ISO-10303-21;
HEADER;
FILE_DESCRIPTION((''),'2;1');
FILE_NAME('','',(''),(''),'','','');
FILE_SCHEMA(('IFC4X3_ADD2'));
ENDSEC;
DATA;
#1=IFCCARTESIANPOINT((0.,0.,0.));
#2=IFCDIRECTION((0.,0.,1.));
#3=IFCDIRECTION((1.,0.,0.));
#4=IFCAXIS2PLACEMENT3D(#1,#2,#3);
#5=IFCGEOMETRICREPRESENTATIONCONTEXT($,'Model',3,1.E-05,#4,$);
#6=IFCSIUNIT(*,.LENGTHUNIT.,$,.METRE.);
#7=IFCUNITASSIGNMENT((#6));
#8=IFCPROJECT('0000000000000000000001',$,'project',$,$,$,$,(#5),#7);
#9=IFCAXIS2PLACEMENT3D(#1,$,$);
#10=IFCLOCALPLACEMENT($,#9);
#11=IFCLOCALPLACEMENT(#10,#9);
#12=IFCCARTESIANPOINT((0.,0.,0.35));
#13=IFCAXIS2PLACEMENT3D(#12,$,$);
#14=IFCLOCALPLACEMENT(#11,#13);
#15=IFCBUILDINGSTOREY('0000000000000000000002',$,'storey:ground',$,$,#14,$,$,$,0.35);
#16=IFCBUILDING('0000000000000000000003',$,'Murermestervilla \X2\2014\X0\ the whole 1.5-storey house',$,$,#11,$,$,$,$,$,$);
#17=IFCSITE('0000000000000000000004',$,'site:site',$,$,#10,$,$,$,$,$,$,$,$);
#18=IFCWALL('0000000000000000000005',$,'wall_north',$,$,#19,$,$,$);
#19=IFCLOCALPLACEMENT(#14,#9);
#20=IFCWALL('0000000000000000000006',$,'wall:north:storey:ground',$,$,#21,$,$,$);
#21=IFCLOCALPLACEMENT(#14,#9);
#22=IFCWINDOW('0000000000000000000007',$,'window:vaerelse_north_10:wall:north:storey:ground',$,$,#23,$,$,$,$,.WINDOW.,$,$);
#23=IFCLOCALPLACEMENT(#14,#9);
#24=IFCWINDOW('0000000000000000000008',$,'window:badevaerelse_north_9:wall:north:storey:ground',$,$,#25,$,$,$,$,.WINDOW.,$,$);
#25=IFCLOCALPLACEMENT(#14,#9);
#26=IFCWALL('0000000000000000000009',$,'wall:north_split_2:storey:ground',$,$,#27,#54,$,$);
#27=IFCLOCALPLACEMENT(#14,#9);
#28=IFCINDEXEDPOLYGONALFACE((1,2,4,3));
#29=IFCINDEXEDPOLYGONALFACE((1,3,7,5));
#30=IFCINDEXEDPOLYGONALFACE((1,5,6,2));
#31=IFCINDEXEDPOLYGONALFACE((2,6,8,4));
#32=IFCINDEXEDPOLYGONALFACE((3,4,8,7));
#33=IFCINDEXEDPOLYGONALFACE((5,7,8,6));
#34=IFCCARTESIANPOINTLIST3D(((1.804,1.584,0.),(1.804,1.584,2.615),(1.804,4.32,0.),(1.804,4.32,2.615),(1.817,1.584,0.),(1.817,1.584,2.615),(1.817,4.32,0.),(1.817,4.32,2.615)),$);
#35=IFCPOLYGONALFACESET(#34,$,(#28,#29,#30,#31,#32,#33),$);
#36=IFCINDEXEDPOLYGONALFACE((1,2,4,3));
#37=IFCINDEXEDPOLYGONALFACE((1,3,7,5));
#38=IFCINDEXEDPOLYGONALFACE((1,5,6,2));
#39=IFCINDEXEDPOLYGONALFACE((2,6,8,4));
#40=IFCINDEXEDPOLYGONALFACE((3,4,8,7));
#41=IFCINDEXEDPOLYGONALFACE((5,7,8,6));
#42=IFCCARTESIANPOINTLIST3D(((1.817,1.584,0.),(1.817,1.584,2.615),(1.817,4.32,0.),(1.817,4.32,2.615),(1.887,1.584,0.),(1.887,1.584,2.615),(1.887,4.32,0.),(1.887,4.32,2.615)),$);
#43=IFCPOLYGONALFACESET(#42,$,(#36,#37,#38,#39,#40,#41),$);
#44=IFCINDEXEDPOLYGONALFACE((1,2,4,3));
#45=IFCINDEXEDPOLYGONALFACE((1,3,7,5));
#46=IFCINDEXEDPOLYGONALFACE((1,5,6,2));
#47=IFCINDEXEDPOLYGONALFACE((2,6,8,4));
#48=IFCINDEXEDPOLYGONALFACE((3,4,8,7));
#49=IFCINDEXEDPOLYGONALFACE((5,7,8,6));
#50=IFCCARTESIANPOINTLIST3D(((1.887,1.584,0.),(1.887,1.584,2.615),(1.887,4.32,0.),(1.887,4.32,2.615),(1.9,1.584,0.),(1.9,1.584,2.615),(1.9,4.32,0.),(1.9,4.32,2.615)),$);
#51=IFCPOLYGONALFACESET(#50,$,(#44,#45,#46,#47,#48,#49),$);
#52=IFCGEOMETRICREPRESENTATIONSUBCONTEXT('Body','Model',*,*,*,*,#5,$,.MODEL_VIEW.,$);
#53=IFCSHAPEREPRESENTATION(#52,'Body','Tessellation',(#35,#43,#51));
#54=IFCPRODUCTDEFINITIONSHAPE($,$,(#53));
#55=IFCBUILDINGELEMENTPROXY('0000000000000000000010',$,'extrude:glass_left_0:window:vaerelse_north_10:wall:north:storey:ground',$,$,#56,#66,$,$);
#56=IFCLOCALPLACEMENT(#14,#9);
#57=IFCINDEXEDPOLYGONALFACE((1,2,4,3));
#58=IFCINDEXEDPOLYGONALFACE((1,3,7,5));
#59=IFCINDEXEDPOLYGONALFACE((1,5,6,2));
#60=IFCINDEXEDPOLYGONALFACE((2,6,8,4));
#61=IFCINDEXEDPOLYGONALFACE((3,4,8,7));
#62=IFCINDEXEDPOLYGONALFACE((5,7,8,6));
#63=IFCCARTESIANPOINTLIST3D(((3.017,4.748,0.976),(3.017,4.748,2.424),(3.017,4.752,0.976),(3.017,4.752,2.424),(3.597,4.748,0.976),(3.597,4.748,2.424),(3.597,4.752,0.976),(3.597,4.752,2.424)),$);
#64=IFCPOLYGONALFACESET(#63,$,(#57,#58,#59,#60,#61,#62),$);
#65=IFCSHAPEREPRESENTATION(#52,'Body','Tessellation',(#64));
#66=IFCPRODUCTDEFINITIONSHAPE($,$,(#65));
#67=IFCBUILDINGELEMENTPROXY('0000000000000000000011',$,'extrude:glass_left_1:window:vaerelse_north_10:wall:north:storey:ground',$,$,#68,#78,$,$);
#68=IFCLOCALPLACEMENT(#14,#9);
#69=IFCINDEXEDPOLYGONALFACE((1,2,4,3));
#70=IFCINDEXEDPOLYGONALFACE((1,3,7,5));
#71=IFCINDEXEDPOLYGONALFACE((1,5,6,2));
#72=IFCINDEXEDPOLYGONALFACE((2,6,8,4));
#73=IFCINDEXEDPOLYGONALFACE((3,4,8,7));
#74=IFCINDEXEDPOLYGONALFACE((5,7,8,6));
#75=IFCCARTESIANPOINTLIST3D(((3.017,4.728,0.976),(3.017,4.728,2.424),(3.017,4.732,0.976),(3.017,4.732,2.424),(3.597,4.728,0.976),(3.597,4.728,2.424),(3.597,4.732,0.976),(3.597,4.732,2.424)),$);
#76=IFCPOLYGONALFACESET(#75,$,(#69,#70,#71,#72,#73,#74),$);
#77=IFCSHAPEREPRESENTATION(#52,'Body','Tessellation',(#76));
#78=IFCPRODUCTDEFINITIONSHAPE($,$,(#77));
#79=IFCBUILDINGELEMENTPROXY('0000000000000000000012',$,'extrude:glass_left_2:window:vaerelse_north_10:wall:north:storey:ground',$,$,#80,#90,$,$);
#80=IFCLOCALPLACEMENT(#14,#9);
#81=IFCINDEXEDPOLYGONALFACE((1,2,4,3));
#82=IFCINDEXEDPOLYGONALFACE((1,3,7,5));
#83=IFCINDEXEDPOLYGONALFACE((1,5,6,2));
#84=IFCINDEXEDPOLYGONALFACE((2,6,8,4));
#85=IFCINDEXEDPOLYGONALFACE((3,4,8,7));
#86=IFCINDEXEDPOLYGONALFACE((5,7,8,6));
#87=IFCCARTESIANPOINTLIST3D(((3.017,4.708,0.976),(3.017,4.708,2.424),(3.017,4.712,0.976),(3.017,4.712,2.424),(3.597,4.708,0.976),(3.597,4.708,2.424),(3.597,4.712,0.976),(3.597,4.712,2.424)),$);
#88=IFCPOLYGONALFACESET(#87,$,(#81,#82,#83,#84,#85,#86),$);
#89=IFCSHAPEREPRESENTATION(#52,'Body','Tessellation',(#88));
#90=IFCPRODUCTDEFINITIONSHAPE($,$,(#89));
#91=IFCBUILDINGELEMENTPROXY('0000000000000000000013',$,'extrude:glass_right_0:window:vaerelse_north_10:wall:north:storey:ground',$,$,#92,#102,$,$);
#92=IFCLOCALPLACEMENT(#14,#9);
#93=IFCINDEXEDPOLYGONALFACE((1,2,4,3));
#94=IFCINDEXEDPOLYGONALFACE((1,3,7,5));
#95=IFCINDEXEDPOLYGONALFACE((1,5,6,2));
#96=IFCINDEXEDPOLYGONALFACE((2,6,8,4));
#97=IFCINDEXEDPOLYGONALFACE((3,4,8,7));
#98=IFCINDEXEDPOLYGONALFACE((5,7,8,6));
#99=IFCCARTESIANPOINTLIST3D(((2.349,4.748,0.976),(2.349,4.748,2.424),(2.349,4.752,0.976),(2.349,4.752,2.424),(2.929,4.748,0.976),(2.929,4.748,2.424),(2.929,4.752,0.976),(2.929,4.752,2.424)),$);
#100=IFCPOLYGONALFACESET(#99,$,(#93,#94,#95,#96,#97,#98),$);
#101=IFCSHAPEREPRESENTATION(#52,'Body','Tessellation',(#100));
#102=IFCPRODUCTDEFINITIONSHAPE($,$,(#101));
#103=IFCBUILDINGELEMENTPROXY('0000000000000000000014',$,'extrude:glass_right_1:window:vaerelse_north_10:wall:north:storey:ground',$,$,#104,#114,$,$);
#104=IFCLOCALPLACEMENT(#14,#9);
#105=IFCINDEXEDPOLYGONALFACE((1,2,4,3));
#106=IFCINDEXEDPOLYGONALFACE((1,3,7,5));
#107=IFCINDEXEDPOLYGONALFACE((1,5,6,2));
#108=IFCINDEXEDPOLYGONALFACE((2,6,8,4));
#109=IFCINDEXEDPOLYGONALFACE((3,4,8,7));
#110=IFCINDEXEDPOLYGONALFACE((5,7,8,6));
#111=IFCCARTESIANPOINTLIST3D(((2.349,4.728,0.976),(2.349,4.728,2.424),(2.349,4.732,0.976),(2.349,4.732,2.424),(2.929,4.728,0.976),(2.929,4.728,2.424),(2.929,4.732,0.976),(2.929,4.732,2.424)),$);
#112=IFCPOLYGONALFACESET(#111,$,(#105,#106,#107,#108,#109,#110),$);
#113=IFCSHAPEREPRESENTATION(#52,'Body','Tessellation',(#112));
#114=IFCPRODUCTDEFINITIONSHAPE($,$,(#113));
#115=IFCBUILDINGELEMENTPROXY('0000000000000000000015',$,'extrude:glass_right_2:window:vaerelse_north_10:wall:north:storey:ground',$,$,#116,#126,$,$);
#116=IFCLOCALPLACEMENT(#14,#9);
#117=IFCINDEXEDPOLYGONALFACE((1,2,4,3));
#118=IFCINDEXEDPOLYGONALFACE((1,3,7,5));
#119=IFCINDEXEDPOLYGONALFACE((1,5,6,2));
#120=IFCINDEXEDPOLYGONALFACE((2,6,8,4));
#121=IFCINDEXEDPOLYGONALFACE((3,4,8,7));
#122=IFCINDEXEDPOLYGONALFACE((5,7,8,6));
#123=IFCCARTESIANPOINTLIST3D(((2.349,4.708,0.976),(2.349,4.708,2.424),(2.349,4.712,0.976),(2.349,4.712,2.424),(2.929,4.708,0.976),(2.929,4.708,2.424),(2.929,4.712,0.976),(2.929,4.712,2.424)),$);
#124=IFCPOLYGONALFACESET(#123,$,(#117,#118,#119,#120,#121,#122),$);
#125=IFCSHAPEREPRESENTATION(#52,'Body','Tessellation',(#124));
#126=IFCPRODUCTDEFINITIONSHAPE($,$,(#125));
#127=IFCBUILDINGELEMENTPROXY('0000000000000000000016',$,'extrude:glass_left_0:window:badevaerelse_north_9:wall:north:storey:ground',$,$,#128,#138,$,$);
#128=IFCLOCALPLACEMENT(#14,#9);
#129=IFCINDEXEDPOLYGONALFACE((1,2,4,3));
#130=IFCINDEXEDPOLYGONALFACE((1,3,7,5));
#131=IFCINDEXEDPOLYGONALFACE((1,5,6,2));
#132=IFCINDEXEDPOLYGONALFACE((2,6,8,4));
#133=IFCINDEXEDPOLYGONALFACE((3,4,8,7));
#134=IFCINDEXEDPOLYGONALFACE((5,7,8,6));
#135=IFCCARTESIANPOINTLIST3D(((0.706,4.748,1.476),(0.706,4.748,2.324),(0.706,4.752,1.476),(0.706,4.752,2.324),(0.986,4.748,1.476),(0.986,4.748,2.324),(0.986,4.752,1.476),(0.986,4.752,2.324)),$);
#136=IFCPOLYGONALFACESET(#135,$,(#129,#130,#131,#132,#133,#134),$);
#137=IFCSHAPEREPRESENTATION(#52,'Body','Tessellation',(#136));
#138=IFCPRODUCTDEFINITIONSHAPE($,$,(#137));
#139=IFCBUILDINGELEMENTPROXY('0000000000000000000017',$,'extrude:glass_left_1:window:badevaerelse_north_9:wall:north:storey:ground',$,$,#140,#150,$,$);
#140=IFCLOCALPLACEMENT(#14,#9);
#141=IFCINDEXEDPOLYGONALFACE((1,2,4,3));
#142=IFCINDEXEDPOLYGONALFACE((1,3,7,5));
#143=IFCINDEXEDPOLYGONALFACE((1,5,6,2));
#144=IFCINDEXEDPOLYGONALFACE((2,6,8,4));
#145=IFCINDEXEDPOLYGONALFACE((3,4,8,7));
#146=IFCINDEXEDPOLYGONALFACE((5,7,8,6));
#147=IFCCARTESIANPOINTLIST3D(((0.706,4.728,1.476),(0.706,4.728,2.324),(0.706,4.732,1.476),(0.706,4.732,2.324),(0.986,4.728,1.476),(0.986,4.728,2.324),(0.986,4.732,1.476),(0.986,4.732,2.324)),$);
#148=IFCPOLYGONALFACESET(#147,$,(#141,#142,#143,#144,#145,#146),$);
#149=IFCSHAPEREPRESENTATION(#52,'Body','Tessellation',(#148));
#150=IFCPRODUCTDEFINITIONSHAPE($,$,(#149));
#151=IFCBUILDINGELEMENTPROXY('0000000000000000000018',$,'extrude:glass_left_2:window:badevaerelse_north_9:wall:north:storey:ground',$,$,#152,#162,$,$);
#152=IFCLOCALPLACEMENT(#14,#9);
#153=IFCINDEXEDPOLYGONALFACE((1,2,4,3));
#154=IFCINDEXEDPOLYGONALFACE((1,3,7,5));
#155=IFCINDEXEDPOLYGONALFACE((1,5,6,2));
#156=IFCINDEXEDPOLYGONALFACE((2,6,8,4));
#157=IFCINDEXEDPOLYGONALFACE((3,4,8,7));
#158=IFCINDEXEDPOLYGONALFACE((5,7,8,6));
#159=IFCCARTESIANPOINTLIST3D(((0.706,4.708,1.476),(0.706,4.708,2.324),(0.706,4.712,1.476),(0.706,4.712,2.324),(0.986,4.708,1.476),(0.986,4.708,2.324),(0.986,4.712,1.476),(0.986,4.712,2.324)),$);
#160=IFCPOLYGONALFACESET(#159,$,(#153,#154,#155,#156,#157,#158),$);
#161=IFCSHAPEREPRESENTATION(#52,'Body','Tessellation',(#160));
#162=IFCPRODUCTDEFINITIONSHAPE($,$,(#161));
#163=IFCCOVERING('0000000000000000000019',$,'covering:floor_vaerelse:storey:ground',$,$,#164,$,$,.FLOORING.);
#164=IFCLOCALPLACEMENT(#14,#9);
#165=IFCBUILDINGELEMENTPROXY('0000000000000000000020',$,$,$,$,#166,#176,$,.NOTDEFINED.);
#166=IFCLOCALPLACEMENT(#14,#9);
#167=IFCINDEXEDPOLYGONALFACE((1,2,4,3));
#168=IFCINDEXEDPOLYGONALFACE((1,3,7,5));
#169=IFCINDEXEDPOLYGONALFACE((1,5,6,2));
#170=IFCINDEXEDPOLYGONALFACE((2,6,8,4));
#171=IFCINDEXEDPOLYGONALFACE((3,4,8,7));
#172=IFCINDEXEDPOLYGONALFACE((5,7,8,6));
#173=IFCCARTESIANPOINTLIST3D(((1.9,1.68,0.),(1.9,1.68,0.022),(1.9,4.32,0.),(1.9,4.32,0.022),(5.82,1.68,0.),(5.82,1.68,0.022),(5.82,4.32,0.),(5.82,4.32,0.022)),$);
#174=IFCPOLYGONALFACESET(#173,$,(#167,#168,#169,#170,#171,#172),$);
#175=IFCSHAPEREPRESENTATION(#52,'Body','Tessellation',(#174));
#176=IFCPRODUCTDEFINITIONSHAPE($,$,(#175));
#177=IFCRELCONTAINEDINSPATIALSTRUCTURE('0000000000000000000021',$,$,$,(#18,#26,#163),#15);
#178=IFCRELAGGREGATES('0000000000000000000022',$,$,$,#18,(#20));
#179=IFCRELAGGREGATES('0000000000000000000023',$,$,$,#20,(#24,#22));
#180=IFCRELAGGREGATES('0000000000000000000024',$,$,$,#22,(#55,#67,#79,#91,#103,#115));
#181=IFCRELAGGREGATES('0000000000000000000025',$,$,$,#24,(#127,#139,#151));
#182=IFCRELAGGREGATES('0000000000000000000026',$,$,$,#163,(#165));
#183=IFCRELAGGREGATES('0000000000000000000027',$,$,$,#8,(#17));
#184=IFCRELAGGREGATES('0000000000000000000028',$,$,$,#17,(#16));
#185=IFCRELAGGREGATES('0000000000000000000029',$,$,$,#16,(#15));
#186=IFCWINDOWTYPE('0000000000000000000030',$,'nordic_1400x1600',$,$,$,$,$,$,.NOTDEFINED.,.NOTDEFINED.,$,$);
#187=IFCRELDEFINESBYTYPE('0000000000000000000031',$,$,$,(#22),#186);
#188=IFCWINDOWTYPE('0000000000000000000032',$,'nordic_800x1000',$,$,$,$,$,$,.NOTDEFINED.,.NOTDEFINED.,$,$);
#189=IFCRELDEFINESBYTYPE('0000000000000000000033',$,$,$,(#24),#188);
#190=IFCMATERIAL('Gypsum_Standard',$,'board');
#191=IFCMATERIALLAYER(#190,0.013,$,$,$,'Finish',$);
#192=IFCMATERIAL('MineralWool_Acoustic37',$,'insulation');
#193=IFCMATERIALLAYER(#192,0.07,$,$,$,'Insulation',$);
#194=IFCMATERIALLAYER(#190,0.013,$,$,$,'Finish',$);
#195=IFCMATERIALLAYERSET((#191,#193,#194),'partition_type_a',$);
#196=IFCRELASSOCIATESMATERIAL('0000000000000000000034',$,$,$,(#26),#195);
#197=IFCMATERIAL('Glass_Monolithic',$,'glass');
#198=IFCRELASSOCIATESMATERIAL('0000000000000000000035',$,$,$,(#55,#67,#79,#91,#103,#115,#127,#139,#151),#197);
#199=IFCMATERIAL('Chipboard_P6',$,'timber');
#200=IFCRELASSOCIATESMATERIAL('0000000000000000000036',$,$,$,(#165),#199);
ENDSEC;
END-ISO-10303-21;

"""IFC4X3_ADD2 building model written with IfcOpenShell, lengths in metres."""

from ifc_helpers import new_model, si_unit, frame, origin, origin_with_axes, place, context, subcontext, project, spatial, polyline, rectangle, outline, extrude, source, transform, mapped, material, layer, layer_set, layer_usage, type_object, element, aggregate, save


model = new_model("IFC4X3_ADD2")

# Units and contexts
model_context = context("Model", 3, precision=1e-05, world=origin_with_axes())
body_context = subcontext(model_context, "Body", "Model", "MODEL_VIEW")
ifc_project = project(units=[si_unit("LENGTHUNIT", "METRE")], contexts=[model_context])

# Site, building, storey
site_placement = place(None, origin())
site = spatial("IfcSite", under=ifc_project, at=site_placement, Name="site:site")
building_placement = place(site_placement, origin())
building = spatial("IfcBuilding", under=site, at=building_placement, Name="Murermestervilla — the whole 1.5-storey house")
storey_placement = place(building_placement, frame((0.0, 0.0, 0.35)))
storey = spatial("IfcBuildingStorey", under=building, at=storey_placement, Name="storey:ground", Elevation=0.35)

# Walls, windows
wall_1_placement = place(storey_placement, origin())
wall_1 = element("IfcWall", 1, at=wall_1_placement, inside=storey, Name="wall_north")
wall_2_placement = place(wall_1_placement, frame((0.0, 0.0, -0.35)))
wall_2 = element("IfcWall", 2, at=wall_2_placement, Name="wall:north:storey:ground")
aggregate(wall_1, [wall_2])
window_type_1 = type_object("IfcWindowType", Name="nordic_1400x1600", PartitioningType="NOTDEFINED", PredefinedType="NOTDEFINED")
window_1_placement = place(None, frame((2.973, 4.828, 1.25), z_axis=(0.0, 0.0, 1.0), x_axis=(-1.0, 0.0, 0.0)))
window_1 = element("IfcWindow", 3, at=window_1_placement, type_object=window_type_1, Name="window:vaerelse_north_10:wall:north:storey:ground", PredefinedType="WINDOW")
window_type_2 = type_object("IfcWindowType", Name="nordic_800x1000", PartitioningType="NOTDEFINED", PredefinedType="NOTDEFINED")
window_2_placement = place(None, frame((0.662, 4.828, 1.75), z_axis=(0.0, 0.0, 1.0), x_axis=(-1.0, 0.0, 0.0)))
window_2 = element("IfcWindow", 4, at=window_2_placement, type_object=window_type_2, Name="window:badevaerelse_north_9:wall:north:storey:ground", PredefinedType="WINDOW")
aggregate(wall_2, [window_2, window_1])

# Shared definitions
ifc_material_1 = material(Name="Gypsum_Standard", Category="board")
ifc_layer_1 = layer(ifc_material_1, 0.013, Category="Finish")
ifc_material_2 = material(Name="MineralWool_Acoustic37", Category="insulation")
ifc_layer_2 = layer(ifc_material_2, 0.07, Category="Insulation")
ifc_layer_3 = layer(ifc_material_1, 0.013, Category="Finish")
ifc_layer_set = layer_set([ifc_layer_1, ifc_layer_2, ifc_layer_3], Name="partition_type_a")

# Wall
ifc_layer_usage_1 = layer_usage(ifc_layer_set, "AXIS1", "NEGATIVE", 0.048)
wall_3_placement = place(storey_placement, frame((1.852, 2.952, 1.3075)))
element("IfcWall", 5, at=wall_3_placement, inside=storey, material=ifc_layer_usage_1, Name="wall:north_split_2:storey:ground", context=body_context, shape_type="SweptSolid", body=[
    extrude(rectangle(XDim=0.013, YDim=2.736), frame((-0.0415, 0.0, -1.3075)), (0.0, 0.0, 1.0), 2.615),
    extrude(rectangle(XDim=0.07, YDim=2.736), frame((0.0, 0.0, -1.3075)), (0.0, 0.0, 1.0), 2.615),
    extrude(rectangle(XDim=0.013, YDim=2.736), frame((0.0415, 0.0, -1.3075)), (0.0, 0.0, 1.0), 2.615),
])

# Building element proxies
ifc_material_3 = material(Name="Glass_Monolithic", Category="glass")
shared_shape_1 = source(origin(), body_context, "Body", "SweptSolid", [
    extrude(outline(polyline([(-0.29, -0.724), (0.29, -0.724), (0.29, 0.724), (-0.29, 0.724), (-0.29, -0.724)])), frame((0.0, 0.0, -0.002)), (0.0, 0.0, 1.0), 0.004),
])
proxy_1_placement = place(None, frame((3.307, 4.75, 2.05), z_axis=(0.0, 1.0, 0.0), x_axis=(-1.0, 0.0, 0.0)))
proxy_1 = element("IfcBuildingElementProxy", 6, at=proxy_1_placement, material=ifc_material_3, Name="extrude:glass_left_0:window:vaerelse_north_10:wall:north:storey:ground", context=body_context, shape_type="MappedRepresentation", body=[
    mapped(shared_shape_1, transform((0.0, 0.0, 0.0))),
])
shared_shape_2 = source(origin(), body_context, "Body", "SweptSolid", [
    extrude(outline(polyline([(-0.29, -0.724), (0.29, -0.724), (0.29, 0.724), (-0.29, 0.724), (-0.29, -0.724)])), frame((0.0, 0.0, -0.002)), (0.0, 0.0, 1.0), 0.004),
])
proxy_2_placement = place(None, frame((3.307, 4.73, 2.05), z_axis=(0.0, 1.0, 0.0), x_axis=(-1.0, 0.0, 0.0)))
proxy_2 = element("IfcBuildingElementProxy", 7, at=proxy_2_placement, material=ifc_material_3, Name="extrude:glass_left_1:window:vaerelse_north_10:wall:north:storey:ground", context=body_context, shape_type="MappedRepresentation", body=[
    mapped(shared_shape_2, transform((0.0, 0.0, 0.0))),
])
shared_shape_3 = source(origin(), body_context, "Body", "SweptSolid", [
    extrude(outline(polyline([(-0.29, -0.724), (0.29, -0.724), (0.29, 0.724), (-0.29, 0.724), (-0.29, -0.724)])), frame((0.0, 0.0, -0.002)), (0.0, 0.0, 1.0), 0.004),
])
proxy_3_placement = place(None, frame((3.307, 4.71, 2.05), z_axis=(0.0, 1.0, 0.0), x_axis=(-1.0, 0.0, 0.0)))
proxy_3 = element("IfcBuildingElementProxy", 8, at=proxy_3_placement, material=ifc_material_3, Name="extrude:glass_left_2:window:vaerelse_north_10:wall:north:storey:ground", context=body_context, shape_type="MappedRepresentation", body=[
    mapped(shared_shape_3, transform((0.0, 0.0, 0.0))),
])
shared_shape_4 = source(origin(), body_context, "Body", "SweptSolid", [
    extrude(outline(polyline([(-0.29, -0.724), (0.29, -0.724), (0.29, 0.724), (-0.29, 0.724), (-0.29, -0.724)])), frame((0.0, 0.0, -0.002)), (0.0, 0.0, 1.0), 0.004),
])
proxy_4_placement = place(None, frame((2.639, 4.75, 2.05), z_axis=(0.0, 1.0, 0.0), x_axis=(-1.0, 0.0, 0.0)))
proxy_4 = element("IfcBuildingElementProxy", 9, at=proxy_4_placement, material=ifc_material_3, Name="extrude:glass_right_0:window:vaerelse_north_10:wall:north:storey:ground", context=body_context, shape_type="MappedRepresentation", body=[
    mapped(shared_shape_4, transform((0.0, 0.0, 0.0))),
])
shared_shape_5 = source(origin(), body_context, "Body", "SweptSolid", [
    extrude(outline(polyline([(-0.29, -0.724), (0.29, -0.724), (0.29, 0.724), (-0.29, 0.724), (-0.29, -0.724)])), frame((0.0, 0.0, -0.002)), (0.0, 0.0, 1.0), 0.004),
])
proxy_5_placement = place(None, frame((2.639, 4.73, 2.05), z_axis=(0.0, 1.0, 0.0), x_axis=(-1.0, 0.0, 0.0)))
proxy_5 = element("IfcBuildingElementProxy", 10, at=proxy_5_placement, material=ifc_material_3, Name="extrude:glass_right_1:window:vaerelse_north_10:wall:north:storey:ground", context=body_context, shape_type="MappedRepresentation", body=[
    mapped(shared_shape_5, transform((0.0, 0.0, 0.0))),
])
shared_shape_6 = source(origin(), body_context, "Body", "SweptSolid", [
    extrude(outline(polyline([(-0.29, -0.724), (0.29, -0.724), (0.29, 0.724), (-0.29, 0.724), (-0.29, -0.724)])), frame((0.0, 0.0, -0.002)), (0.0, 0.0, 1.0), 0.004),
])
proxy_6_placement = place(None, frame((2.639, 4.71, 2.05), z_axis=(0.0, 1.0, 0.0), x_axis=(-1.0, 0.0, 0.0)))
proxy_6 = element("IfcBuildingElementProxy", 11, at=proxy_6_placement, material=ifc_material_3, Name="extrude:glass_right_2:window:vaerelse_north_10:wall:north:storey:ground", context=body_context, shape_type="MappedRepresentation", body=[
    mapped(shared_shape_6, transform((0.0, 0.0, 0.0))),
])
aggregate(window_1, [proxy_1, proxy_2, proxy_3, proxy_4, proxy_5, proxy_6])
shared_shape_7 = source(origin(), body_context, "Body", "SweptSolid", [
    extrude(outline(polyline([(-0.14, -0.424), (0.14, -0.424), (0.14, 0.424), (-0.14, 0.424), (-0.14, -0.424)])), frame((0.0, 0.0, -0.002)), (0.0, 0.0, 1.0), 0.004),
])
proxy_7_placement = place(None, frame((0.846, 4.75, 2.25), z_axis=(0.0, 1.0, 0.0), x_axis=(-1.0, 0.0, 0.0)))
proxy_7 = element("IfcBuildingElementProxy", 12, at=proxy_7_placement, material=ifc_material_3, Name="extrude:glass_left_0:window:badevaerelse_north_9:wall:north:storey:ground", context=body_context, shape_type="MappedRepresentation", body=[
    mapped(shared_shape_7, transform((0.0, 0.0, 0.0))),
])
shared_shape_8 = source(origin(), body_context, "Body", "SweptSolid", [
    extrude(outline(polyline([(-0.14, -0.424), (0.14, -0.424), (0.14, 0.424), (-0.14, 0.424), (-0.14, -0.424)])), frame((0.0, 0.0, -0.002)), (0.0, 0.0, 1.0), 0.004),
])
proxy_8_placement = place(None, frame((0.846, 4.73, 2.25), z_axis=(0.0, 1.0, 0.0), x_axis=(-1.0, 0.0, 0.0)))
proxy_8 = element("IfcBuildingElementProxy", 13, at=proxy_8_placement, material=ifc_material_3, Name="extrude:glass_left_1:window:badevaerelse_north_9:wall:north:storey:ground", context=body_context, shape_type="MappedRepresentation", body=[
    mapped(shared_shape_8, transform((0.0, 0.0, 0.0))),
])
shared_shape_9 = source(origin(), body_context, "Body", "SweptSolid", [
    extrude(outline(polyline([(-0.14, -0.424), (0.14, -0.424), (0.14, 0.424), (-0.14, 0.424), (-0.14, -0.424)])), frame((0.0, 0.0, -0.002)), (0.0, 0.0, 1.0), 0.004),
])
proxy_9_placement = place(None, frame((0.846, 4.71, 2.25), z_axis=(0.0, 1.0, 0.0), x_axis=(-1.0, 0.0, 0.0)))
proxy_9 = element("IfcBuildingElementProxy", 14, at=proxy_9_placement, material=ifc_material_3, Name="extrude:glass_left_2:window:badevaerelse_north_9:wall:north:storey:ground", context=body_context, shape_type="MappedRepresentation", body=[
    mapped(shared_shape_9, transform((0.0, 0.0, 0.0))),
])
aggregate(window_2, [proxy_7, proxy_8, proxy_9])

# Shared definitions
placement_1 = place(storey_placement, frame((0.0, 0.0, -0.35)))

# Covering, building element proxy
covering = element("IfcCovering", 15, at=placement_1, inside=storey, Name="covering:floor_vaerelse:storey:ground", PredefinedType="FLOORING")
ifc_material_4 = material(Name="Chipboard_P6", Category="timber")
proxy_10_placement = place(None, frame((3.86, 3.0, 0.361)))
proxy_10 = element("IfcBuildingElementProxy", 16, at=proxy_10_placement, material=ifc_material_4, PredefinedType="NOTDEFINED", context=body_context, shape_type="SweptSolid", body=[
    extrude(rectangle(XDim=3.92, YDim=2.64), frame((0.0, 0.0, -0.011)), (0.0, 0.0, 1.0), 0.022),
])
aggregate(covering, [proxy_10])

save(model, "model.ifc")
